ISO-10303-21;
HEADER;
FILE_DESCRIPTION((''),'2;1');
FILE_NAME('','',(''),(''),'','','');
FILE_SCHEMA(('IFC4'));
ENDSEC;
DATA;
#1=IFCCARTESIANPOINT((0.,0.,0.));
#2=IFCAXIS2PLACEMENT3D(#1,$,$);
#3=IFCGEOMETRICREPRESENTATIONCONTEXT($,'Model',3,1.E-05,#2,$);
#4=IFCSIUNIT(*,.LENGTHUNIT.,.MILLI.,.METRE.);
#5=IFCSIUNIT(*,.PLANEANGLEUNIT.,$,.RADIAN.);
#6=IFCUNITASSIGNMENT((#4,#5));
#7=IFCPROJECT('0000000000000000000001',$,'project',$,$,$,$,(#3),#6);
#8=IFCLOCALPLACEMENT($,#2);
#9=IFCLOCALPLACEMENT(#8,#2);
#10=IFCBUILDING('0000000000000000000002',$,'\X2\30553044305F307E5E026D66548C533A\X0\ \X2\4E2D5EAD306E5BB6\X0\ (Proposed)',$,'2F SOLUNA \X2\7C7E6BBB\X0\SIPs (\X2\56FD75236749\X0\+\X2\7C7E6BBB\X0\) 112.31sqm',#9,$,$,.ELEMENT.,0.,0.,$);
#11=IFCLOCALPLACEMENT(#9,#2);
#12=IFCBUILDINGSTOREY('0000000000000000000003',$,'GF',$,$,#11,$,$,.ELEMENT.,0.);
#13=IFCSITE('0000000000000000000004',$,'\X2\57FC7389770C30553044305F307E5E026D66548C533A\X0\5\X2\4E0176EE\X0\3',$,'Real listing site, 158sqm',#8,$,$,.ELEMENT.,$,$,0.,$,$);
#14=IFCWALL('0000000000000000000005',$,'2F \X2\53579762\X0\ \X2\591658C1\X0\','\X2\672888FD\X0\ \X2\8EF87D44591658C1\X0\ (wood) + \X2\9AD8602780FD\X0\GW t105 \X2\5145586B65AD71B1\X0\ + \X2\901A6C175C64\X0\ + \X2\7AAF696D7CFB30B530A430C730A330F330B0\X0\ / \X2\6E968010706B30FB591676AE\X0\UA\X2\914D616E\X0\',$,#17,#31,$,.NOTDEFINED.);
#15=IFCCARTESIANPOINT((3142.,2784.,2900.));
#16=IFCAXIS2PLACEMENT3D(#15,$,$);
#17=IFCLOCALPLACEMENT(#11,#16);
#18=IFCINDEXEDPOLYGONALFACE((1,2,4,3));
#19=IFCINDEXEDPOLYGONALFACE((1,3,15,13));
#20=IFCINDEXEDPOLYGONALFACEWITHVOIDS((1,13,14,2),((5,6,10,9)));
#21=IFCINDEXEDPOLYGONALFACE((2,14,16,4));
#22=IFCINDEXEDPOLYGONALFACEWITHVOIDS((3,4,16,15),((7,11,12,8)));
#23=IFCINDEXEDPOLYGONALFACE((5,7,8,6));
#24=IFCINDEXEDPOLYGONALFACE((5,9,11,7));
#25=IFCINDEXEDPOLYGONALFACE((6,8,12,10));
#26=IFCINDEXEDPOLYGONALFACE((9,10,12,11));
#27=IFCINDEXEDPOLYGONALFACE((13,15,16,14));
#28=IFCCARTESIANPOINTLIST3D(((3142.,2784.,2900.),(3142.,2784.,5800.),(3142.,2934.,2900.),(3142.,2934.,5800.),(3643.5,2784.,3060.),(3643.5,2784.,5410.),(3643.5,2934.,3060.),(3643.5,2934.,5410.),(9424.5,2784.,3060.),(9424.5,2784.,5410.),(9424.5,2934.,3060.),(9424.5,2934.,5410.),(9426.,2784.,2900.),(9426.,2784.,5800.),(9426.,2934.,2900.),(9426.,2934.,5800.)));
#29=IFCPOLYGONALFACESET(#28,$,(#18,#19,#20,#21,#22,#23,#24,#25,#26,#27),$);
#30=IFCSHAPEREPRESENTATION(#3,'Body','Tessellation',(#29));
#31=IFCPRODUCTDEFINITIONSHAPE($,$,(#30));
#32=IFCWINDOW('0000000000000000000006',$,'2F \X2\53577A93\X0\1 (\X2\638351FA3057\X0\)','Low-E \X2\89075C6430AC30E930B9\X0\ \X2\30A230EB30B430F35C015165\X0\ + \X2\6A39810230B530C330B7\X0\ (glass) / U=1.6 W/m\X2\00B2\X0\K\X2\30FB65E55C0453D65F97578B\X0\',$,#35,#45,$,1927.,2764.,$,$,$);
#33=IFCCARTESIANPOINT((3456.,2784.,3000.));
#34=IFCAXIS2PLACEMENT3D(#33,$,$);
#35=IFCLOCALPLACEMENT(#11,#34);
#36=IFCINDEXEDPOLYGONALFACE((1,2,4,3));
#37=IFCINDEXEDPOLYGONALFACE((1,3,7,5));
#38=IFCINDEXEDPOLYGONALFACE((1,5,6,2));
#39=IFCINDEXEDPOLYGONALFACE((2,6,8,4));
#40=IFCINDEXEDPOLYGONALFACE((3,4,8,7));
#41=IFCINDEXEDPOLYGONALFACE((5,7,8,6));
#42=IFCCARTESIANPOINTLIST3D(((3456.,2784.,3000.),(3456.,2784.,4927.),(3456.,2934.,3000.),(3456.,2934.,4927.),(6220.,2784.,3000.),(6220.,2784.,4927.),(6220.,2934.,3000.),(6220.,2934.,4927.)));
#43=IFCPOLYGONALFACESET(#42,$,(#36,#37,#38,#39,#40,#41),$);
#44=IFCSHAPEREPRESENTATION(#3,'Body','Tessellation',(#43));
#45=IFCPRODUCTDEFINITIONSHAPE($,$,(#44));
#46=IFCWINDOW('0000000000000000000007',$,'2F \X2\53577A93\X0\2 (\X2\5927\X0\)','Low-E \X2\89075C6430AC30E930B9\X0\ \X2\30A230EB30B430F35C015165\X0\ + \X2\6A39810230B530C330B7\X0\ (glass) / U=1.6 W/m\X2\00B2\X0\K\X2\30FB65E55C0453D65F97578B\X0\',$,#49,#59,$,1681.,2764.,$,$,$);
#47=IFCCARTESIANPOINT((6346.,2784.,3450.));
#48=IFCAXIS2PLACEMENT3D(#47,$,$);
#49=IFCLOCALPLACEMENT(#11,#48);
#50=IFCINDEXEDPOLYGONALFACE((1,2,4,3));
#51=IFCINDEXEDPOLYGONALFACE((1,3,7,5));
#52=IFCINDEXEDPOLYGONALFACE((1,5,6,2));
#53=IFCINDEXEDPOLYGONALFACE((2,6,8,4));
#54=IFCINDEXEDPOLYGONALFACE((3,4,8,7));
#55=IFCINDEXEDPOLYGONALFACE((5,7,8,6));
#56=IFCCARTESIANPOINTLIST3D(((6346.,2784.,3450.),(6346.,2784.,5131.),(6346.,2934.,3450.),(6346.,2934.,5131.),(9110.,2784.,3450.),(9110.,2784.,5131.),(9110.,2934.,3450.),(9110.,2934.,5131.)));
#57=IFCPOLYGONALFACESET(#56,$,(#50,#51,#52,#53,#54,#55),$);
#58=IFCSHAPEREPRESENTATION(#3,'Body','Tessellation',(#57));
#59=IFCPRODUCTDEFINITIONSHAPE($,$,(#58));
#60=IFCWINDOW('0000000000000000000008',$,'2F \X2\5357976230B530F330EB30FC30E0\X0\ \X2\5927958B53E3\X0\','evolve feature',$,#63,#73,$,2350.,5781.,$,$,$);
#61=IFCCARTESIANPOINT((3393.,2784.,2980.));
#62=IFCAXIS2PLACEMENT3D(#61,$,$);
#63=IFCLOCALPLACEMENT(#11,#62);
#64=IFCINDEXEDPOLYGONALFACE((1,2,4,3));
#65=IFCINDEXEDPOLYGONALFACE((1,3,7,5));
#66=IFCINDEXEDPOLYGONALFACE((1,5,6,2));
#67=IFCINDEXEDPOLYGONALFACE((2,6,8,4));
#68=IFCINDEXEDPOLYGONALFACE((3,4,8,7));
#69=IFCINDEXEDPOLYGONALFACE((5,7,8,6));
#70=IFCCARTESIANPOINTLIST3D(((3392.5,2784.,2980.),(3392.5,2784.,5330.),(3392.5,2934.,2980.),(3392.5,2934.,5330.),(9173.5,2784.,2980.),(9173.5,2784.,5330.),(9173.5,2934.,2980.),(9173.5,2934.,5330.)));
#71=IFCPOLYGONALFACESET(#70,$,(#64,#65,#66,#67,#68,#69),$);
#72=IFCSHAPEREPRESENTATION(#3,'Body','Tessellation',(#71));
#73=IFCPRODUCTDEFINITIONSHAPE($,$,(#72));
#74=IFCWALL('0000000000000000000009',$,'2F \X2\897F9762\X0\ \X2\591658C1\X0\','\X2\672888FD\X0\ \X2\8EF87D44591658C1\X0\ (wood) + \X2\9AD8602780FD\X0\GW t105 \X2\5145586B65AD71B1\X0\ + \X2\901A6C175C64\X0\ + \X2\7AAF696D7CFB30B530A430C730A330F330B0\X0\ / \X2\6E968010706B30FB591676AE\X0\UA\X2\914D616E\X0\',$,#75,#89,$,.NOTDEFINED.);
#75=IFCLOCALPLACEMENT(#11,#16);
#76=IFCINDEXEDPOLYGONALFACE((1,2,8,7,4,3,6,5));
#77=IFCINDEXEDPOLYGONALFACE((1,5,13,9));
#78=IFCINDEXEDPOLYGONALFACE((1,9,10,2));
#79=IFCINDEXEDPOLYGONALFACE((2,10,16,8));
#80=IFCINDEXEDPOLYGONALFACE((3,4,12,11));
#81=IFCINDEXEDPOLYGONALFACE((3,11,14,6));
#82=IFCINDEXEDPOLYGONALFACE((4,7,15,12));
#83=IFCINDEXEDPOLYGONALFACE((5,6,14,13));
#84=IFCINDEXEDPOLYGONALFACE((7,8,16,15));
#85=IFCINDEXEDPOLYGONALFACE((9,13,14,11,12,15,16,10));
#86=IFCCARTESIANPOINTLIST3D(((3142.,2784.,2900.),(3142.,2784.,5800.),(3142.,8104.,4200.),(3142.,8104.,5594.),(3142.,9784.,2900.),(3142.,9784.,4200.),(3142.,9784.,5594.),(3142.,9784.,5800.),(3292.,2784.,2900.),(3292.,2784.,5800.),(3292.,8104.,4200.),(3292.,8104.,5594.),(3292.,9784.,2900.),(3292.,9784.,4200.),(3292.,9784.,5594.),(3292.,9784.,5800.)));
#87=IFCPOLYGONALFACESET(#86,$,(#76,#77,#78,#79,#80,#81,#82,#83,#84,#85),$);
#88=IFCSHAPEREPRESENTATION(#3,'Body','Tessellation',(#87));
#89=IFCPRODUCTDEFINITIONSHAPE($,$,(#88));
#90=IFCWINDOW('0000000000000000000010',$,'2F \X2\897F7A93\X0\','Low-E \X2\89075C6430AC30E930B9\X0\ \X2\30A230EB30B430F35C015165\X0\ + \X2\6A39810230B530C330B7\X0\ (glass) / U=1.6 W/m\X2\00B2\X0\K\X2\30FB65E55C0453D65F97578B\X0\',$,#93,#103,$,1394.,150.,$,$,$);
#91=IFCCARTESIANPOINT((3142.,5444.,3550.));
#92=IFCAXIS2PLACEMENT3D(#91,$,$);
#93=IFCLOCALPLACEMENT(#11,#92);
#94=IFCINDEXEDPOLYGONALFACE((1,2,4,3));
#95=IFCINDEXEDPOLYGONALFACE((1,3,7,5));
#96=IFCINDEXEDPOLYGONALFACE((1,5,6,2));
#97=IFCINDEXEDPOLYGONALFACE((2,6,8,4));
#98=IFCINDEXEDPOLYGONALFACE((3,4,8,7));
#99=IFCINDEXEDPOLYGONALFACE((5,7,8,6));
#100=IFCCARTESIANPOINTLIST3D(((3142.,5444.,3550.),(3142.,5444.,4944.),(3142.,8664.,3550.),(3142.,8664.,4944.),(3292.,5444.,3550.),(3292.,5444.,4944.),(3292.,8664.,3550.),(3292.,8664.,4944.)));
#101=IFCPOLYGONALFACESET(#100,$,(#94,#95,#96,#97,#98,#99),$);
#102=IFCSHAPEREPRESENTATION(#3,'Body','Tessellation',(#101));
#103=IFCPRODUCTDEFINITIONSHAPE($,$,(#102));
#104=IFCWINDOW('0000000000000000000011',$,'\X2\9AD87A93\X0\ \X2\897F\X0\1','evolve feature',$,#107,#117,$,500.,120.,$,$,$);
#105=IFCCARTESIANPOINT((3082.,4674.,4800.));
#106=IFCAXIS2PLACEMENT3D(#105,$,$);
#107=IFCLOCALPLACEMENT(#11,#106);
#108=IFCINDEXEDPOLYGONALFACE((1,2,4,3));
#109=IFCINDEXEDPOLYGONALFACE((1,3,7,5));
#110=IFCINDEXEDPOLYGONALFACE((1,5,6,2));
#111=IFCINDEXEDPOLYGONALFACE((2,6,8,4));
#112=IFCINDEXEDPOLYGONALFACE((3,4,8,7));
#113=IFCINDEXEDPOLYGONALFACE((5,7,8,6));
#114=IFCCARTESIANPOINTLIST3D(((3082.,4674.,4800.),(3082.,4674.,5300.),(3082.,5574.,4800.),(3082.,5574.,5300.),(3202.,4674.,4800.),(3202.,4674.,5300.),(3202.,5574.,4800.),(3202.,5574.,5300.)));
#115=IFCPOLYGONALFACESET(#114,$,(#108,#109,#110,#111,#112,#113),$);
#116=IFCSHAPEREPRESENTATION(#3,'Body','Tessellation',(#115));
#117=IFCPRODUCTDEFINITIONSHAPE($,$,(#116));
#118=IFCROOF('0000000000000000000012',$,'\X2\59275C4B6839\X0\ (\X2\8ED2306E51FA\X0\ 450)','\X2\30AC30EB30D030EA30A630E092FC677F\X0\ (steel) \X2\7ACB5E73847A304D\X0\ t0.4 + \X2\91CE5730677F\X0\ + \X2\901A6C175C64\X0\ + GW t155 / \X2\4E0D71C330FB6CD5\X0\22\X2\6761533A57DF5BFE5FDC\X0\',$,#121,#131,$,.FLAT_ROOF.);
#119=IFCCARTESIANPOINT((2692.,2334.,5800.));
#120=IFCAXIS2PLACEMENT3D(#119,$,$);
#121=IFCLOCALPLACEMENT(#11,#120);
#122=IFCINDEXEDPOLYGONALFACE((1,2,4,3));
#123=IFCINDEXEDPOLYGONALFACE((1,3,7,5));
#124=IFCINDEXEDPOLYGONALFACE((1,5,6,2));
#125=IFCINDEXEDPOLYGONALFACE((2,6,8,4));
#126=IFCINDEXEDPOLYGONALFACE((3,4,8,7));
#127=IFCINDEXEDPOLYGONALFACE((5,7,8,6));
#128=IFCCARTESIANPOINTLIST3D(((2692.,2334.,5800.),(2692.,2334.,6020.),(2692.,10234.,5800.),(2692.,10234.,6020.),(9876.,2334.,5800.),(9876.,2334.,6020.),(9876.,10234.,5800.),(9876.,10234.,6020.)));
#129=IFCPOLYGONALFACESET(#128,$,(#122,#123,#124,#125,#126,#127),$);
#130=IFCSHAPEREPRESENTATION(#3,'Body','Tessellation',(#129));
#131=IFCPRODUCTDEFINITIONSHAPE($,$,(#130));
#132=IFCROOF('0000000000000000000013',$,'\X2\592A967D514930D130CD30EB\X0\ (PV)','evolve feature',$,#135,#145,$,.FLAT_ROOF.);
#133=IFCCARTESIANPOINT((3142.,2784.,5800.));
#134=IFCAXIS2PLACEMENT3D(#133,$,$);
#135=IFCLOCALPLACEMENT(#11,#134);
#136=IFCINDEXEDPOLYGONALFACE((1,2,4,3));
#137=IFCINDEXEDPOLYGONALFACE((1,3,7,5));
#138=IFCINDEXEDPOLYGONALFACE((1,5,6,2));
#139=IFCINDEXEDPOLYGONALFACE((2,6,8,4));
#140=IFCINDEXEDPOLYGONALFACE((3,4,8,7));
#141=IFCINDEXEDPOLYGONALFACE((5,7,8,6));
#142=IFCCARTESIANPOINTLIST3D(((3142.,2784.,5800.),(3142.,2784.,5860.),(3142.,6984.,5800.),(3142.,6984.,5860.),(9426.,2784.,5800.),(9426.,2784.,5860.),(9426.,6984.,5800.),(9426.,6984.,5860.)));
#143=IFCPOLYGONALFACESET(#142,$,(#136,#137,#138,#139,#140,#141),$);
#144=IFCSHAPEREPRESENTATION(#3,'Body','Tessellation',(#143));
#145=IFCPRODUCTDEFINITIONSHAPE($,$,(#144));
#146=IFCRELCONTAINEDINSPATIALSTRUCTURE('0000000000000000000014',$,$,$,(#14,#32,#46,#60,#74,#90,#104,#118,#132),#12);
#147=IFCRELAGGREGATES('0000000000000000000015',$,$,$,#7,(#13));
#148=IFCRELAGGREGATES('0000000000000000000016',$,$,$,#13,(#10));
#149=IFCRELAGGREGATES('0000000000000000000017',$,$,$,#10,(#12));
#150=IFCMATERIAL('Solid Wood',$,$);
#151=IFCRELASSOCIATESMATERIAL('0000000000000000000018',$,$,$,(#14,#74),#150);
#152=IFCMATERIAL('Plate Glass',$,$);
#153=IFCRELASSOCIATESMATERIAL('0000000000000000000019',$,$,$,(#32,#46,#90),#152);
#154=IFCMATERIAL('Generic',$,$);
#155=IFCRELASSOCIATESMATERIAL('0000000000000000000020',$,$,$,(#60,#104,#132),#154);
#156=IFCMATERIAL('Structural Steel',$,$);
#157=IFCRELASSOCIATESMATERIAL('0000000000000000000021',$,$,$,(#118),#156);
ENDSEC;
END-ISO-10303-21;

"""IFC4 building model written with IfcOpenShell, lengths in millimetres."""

from ifc_helpers import new_model, si_unit, frame, frame_2d, origin, place, context, project, spatial, rectangle, extrude, material, element, fill, save


model = new_model("IFC4")

# Units and contexts
model_context = context("Model", 3, precision=1e-05, world=origin())
ifc_project = project(units=[si_unit("LENGTHUNIT", "METRE", prefix="MILLI"), si_unit("PLANEANGLEUNIT", "RADIAN")], contexts=[model_context])

# Site, building, storey
site_placement = place(None, origin())
site = spatial("IfcSite", under=ifc_project, at=site_placement, Name="埼玉県さいたま市浦和区5丁目3", ObjectType="Real listing site, 158sqm", CompositionType="ELEMENT", RefElevation=0.0)
building_placement = place(site_placement, origin())
building = spatial("IfcBuilding", under=site, at=building_placement, Name="さいたま市浦和区 中庭の家 (Proposed)", ObjectType="2F SOLUNA 籾殻SIPs (国産杉+籾殻) 112.31sqm", CompositionType="ELEMENT", ElevationOfRefHeight=0.0, ElevationOfTerrain=0.0)
storey_placement = place(building_placement, origin())
storey = spatial("IfcBuildingStorey", under=building, at=storey_placement, Name="GF", CompositionType="ELEMENT", Elevation=0.0)

# Shared definitions
ifc_material_1 = material(Name="Solid Wood")
ifc_material_2 = material(Name="Generic")

# Shared definitions
ifc_material_3 = material(Name="Plate Glass")

# Walls, openings, windows
wall_1_placement = place(storey_placement, frame((3142.0, 2784.0, 2900.0)))
wall_1 = element("IfcWall", 1, at=wall_1_placement, inside=storey, material=ifc_material_1, Name="2F 南面 外壁", Description="木製 軸組外壁 (wood) + 高性能GW t105 充填断熱 + 通気層 + 窯業系サイディング / 準耐火・外皮UA配慮", PredefinedType="NOTDEFINED", context=model_context, shape_type="SweptSolid", body=[
    extrude(rectangle(XDim=6284.0, YDim=150.0, at=frame_2d((3142.0, 75.0))), frame((3142.0, 2784.0, 2900.0)), (0.0, 0.0, 1.0), 2900.0),
])
opening_1_placement = place(storey_placement, frame((3456.0, 2784.0, 3000.0)))
opening_1 = element("IfcOpeningElement", 2, at=opening_1_placement, cuts=wall_1, PredefinedType="NOTDEFINED", context=model_context, shape_type="SweptSolid", body=[
    extrude(rectangle(XDim=2764.0, YDim=150.0, at=frame_2d((1382.0, 75.0))), frame((3456.0, 2784.0, 3000.0)), (0.0, 0.0, 1.0), 1927.0),
])
opening_2_placement = place(storey_placement, frame((6346.0, 2784.0, 3450.0)))
opening_2 = element("IfcOpeningElement", 3, at=opening_2_placement, cuts=wall_1, PredefinedType="NOTDEFINED", context=model_context, shape_type="SweptSolid", body=[
    extrude(rectangle(XDim=2764.0, YDim=150.0, at=frame_2d((1382.0, 75.0))), frame((6346.0, 2784.0, 3450.0)), (0.0, 0.0, 1.0), 1681.0),
])
opening_3_placement = place(storey_placement, frame((3393.0, 2784.0, 2980.0)))
opening_3 = element("IfcOpeningElement", 4, at=opening_3_placement, cuts=wall_1, PredefinedType="NOTDEFINED", context=model_context, shape_type="SweptSolid", body=[
    extrude(rectangle(XDim=5781.0, YDim=150.0, at=frame_2d((2890.0, 75.0))), frame((3393.0, 2784.0, 2980.0)), (0.0, 0.0, 1.0), 2350.0),
])
window_1_placement = place(storey_placement, frame((3456.0, 2784.0, 3000.0)))
window_1 = element("IfcWindow", 5, at=window_1_placement, inside=storey, material=ifc_material_3, Name="2F 南窓1 (掃出し)", Description="Low-E 複層ガラス アルゴン封入 + 樹脂サッシ (glass) / U=1.6 W/m²K・日射取得型", OverallHeight=1927.0, OverallWidth=2764.0, context=model_context, shape_type="SweptSolid", body=[
    extrude(rectangle(XDim=2764.0, YDim=150.0, at=frame_2d((1382.0, 75.0))), frame((3456.0, 2784.0, 3000.0)), (0.0, 0.0, 1.0), 1927.0),
])
fill(opening_1, window_1)
window_2_placement = place(storey_placement, frame((6346.0, 2784.0, 3450.0)))
window_2 = element("IfcWindow", 6, at=window_2_placement, inside=storey, material=ifc_material_3, Name="2F 南窓2 (大)", Description="Low-E 複層ガラス アルゴン封入 + 樹脂サッシ (glass) / U=1.6 W/m²K・日射取得型", OverallHeight=1681.0, OverallWidth=2764.0, context=model_context, shape_type="SweptSolid", body=[
    extrude(rectangle(XDim=2764.0, YDim=150.0, at=frame_2d((1382.0, 75.0))), frame((6346.0, 2784.0, 3450.0)), (0.0, 0.0, 1.0), 1681.0),
])
fill(opening_2, window_2)
window_3_placement = place(storey_placement, frame((3393.0, 2784.0, 2980.0)))
window_3 = element("IfcWindow", 7, at=window_3_placement, inside=storey, material=ifc_material_2, Name="2F 南面サンルーム 大開口", Description="evolve feature", OverallHeight=2350.0, OverallWidth=5781.0, context=model_context, shape_type="SweptSolid", body=[
    extrude(rectangle(XDim=5781.0, YDim=150.0, at=frame_2d((2890.0, 75.0))), frame((3393.0, 2784.0, 2980.0)), (0.0, 0.0, 1.0), 2350.0),
])
fill(opening_3, window_3)
wall_2_placement = place(storey_placement, frame((3142.0, 2784.0, 2900.0)))
wall_2 = element("IfcWall", 8, at=wall_2_placement, inside=storey, material=ifc_material_1, Name="2F 西面 外壁", Description="木製 軸組外壁 (wood) + 高性能GW t105 充填断熱 + 通気層 + 窯業系サイディング / 準耐火・外皮UA配慮", PredefinedType="NOTDEFINED", context=model_context, shape_type="SweptSolid", body=[
    extrude(rectangle(XDim=150.0, YDim=7000.0, at=frame_2d((75.0, 3500.0))), frame((3142.0, 2784.0, 2900.0)), (0.0, 0.0, 1.0), 2900.0),
])
opening_4_placement = place(storey_placement, frame((3142.0, 5444.0, 3550.0)))
opening_4 = element("IfcOpeningElement", 9, at=opening_4_placement, cuts=wall_2, PredefinedType="NOTDEFINED", context=model_context, shape_type="SweptSolid", body=[
    extrude(rectangle(XDim=150.0, YDim=3220.0, at=frame_2d((75.0, 1610.0))), frame((3142.0, 5444.0, 3550.0)), (0.0, 0.0, 1.0), 1394.0),
])
opening_5_placement = place(storey_placement, frame((3082.0, 4674.0, 4800.0)))
opening_5 = element("IfcOpeningElement", 10, at=opening_5_placement, cuts=wall_2, PredefinedType="NOTDEFINED", context=model_context, shape_type="SweptSolid", body=[
    extrude(rectangle(XDim=120.0, YDim=900.0, at=frame_2d((60.0, 450.0))), frame((3082.0, 4674.0, 4800.0)), (0.0, 0.0, 1.0), 500.0),
])
window_4_placement = place(storey_placement, frame((3142.0, 5444.0, 3550.0)))
window_4 = element("IfcWindow", 11, at=window_4_placement, inside=storey, material=ifc_material_3, Name="2F 西窓", Description="Low-E 複層ガラス アルゴン封入 + 樹脂サッシ (glass) / U=1.6 W/m²K・日射取得型", OverallHeight=1394.0, OverallWidth=150.0, context=model_context, shape_type="SweptSolid", body=[
    extrude(rectangle(XDim=150.0, YDim=3220.0, at=frame_2d((75.0, 1610.0))), frame((3142.0, 5444.0, 3550.0)), (0.0, 0.0, 1.0), 1394.0),
])
fill(opening_4, window_4)
window_5_placement = place(storey_placement, frame((3082.0, 4674.0, 4800.0)))
window_5 = element("IfcWindow", 12, at=window_5_placement, inside=storey, material=ifc_material_2, Name="高窓 西1", Description="evolve feature", OverallHeight=500.0, OverallWidth=120.0, context=model_context, shape_type="SweptSolid", body=[
    extrude(rectangle(XDim=120.0, YDim=900.0, at=frame_2d((60.0, 450.0))), frame((3082.0, 4674.0, 4800.0)), (0.0, 0.0, 1.0), 500.0),
])
fill(opening_5, window_5)

# Roofs
ifc_material_4 = material(Name="Structural Steel")
roof_1_placement = place(storey_placement, frame((2692.0, 2334.0, 5800.0)))
element("IfcRoof", 13, at=roof_1_placement, inside=storey, material=ifc_material_4, Name="大屋根 (軒の出 450)", Description="ガルバリウム鋼板 (steel) 立平葺き t0.4 + 野地板 + 通気層 + GW t155 / 不燃・法22条区域対応", PredefinedType="FLAT_ROOF", context=model_context, shape_type="SweptSolid", body=[
    extrude(rectangle(XDim=7184.0, YDim=7900.0, at=frame_2d((3592.0, 3950.0))), frame((2692.0, 2334.0, 5800.0)), (0.0, 0.0, 1.0), 220.0),
])
roof_2_placement = place(storey_placement, frame((3142.0, 2784.0, 5800.0)))
element("IfcRoof", 14, at=roof_2_placement, inside=storey, material=ifc_material_2, Name="太陽光パネル (PV)", Description="evolve feature", PredefinedType="FLAT_ROOF", context=model_context, shape_type="SweptSolid", body=[
    extrude(rectangle(XDim=6284.0, YDim=4200.0, at=frame_2d((3142.0, 2100.0))), frame((3142.0, 2784.0, 5800.0)), (0.0, 0.0, 1.0), 60.0),
])

save(model, "model.ifc")
